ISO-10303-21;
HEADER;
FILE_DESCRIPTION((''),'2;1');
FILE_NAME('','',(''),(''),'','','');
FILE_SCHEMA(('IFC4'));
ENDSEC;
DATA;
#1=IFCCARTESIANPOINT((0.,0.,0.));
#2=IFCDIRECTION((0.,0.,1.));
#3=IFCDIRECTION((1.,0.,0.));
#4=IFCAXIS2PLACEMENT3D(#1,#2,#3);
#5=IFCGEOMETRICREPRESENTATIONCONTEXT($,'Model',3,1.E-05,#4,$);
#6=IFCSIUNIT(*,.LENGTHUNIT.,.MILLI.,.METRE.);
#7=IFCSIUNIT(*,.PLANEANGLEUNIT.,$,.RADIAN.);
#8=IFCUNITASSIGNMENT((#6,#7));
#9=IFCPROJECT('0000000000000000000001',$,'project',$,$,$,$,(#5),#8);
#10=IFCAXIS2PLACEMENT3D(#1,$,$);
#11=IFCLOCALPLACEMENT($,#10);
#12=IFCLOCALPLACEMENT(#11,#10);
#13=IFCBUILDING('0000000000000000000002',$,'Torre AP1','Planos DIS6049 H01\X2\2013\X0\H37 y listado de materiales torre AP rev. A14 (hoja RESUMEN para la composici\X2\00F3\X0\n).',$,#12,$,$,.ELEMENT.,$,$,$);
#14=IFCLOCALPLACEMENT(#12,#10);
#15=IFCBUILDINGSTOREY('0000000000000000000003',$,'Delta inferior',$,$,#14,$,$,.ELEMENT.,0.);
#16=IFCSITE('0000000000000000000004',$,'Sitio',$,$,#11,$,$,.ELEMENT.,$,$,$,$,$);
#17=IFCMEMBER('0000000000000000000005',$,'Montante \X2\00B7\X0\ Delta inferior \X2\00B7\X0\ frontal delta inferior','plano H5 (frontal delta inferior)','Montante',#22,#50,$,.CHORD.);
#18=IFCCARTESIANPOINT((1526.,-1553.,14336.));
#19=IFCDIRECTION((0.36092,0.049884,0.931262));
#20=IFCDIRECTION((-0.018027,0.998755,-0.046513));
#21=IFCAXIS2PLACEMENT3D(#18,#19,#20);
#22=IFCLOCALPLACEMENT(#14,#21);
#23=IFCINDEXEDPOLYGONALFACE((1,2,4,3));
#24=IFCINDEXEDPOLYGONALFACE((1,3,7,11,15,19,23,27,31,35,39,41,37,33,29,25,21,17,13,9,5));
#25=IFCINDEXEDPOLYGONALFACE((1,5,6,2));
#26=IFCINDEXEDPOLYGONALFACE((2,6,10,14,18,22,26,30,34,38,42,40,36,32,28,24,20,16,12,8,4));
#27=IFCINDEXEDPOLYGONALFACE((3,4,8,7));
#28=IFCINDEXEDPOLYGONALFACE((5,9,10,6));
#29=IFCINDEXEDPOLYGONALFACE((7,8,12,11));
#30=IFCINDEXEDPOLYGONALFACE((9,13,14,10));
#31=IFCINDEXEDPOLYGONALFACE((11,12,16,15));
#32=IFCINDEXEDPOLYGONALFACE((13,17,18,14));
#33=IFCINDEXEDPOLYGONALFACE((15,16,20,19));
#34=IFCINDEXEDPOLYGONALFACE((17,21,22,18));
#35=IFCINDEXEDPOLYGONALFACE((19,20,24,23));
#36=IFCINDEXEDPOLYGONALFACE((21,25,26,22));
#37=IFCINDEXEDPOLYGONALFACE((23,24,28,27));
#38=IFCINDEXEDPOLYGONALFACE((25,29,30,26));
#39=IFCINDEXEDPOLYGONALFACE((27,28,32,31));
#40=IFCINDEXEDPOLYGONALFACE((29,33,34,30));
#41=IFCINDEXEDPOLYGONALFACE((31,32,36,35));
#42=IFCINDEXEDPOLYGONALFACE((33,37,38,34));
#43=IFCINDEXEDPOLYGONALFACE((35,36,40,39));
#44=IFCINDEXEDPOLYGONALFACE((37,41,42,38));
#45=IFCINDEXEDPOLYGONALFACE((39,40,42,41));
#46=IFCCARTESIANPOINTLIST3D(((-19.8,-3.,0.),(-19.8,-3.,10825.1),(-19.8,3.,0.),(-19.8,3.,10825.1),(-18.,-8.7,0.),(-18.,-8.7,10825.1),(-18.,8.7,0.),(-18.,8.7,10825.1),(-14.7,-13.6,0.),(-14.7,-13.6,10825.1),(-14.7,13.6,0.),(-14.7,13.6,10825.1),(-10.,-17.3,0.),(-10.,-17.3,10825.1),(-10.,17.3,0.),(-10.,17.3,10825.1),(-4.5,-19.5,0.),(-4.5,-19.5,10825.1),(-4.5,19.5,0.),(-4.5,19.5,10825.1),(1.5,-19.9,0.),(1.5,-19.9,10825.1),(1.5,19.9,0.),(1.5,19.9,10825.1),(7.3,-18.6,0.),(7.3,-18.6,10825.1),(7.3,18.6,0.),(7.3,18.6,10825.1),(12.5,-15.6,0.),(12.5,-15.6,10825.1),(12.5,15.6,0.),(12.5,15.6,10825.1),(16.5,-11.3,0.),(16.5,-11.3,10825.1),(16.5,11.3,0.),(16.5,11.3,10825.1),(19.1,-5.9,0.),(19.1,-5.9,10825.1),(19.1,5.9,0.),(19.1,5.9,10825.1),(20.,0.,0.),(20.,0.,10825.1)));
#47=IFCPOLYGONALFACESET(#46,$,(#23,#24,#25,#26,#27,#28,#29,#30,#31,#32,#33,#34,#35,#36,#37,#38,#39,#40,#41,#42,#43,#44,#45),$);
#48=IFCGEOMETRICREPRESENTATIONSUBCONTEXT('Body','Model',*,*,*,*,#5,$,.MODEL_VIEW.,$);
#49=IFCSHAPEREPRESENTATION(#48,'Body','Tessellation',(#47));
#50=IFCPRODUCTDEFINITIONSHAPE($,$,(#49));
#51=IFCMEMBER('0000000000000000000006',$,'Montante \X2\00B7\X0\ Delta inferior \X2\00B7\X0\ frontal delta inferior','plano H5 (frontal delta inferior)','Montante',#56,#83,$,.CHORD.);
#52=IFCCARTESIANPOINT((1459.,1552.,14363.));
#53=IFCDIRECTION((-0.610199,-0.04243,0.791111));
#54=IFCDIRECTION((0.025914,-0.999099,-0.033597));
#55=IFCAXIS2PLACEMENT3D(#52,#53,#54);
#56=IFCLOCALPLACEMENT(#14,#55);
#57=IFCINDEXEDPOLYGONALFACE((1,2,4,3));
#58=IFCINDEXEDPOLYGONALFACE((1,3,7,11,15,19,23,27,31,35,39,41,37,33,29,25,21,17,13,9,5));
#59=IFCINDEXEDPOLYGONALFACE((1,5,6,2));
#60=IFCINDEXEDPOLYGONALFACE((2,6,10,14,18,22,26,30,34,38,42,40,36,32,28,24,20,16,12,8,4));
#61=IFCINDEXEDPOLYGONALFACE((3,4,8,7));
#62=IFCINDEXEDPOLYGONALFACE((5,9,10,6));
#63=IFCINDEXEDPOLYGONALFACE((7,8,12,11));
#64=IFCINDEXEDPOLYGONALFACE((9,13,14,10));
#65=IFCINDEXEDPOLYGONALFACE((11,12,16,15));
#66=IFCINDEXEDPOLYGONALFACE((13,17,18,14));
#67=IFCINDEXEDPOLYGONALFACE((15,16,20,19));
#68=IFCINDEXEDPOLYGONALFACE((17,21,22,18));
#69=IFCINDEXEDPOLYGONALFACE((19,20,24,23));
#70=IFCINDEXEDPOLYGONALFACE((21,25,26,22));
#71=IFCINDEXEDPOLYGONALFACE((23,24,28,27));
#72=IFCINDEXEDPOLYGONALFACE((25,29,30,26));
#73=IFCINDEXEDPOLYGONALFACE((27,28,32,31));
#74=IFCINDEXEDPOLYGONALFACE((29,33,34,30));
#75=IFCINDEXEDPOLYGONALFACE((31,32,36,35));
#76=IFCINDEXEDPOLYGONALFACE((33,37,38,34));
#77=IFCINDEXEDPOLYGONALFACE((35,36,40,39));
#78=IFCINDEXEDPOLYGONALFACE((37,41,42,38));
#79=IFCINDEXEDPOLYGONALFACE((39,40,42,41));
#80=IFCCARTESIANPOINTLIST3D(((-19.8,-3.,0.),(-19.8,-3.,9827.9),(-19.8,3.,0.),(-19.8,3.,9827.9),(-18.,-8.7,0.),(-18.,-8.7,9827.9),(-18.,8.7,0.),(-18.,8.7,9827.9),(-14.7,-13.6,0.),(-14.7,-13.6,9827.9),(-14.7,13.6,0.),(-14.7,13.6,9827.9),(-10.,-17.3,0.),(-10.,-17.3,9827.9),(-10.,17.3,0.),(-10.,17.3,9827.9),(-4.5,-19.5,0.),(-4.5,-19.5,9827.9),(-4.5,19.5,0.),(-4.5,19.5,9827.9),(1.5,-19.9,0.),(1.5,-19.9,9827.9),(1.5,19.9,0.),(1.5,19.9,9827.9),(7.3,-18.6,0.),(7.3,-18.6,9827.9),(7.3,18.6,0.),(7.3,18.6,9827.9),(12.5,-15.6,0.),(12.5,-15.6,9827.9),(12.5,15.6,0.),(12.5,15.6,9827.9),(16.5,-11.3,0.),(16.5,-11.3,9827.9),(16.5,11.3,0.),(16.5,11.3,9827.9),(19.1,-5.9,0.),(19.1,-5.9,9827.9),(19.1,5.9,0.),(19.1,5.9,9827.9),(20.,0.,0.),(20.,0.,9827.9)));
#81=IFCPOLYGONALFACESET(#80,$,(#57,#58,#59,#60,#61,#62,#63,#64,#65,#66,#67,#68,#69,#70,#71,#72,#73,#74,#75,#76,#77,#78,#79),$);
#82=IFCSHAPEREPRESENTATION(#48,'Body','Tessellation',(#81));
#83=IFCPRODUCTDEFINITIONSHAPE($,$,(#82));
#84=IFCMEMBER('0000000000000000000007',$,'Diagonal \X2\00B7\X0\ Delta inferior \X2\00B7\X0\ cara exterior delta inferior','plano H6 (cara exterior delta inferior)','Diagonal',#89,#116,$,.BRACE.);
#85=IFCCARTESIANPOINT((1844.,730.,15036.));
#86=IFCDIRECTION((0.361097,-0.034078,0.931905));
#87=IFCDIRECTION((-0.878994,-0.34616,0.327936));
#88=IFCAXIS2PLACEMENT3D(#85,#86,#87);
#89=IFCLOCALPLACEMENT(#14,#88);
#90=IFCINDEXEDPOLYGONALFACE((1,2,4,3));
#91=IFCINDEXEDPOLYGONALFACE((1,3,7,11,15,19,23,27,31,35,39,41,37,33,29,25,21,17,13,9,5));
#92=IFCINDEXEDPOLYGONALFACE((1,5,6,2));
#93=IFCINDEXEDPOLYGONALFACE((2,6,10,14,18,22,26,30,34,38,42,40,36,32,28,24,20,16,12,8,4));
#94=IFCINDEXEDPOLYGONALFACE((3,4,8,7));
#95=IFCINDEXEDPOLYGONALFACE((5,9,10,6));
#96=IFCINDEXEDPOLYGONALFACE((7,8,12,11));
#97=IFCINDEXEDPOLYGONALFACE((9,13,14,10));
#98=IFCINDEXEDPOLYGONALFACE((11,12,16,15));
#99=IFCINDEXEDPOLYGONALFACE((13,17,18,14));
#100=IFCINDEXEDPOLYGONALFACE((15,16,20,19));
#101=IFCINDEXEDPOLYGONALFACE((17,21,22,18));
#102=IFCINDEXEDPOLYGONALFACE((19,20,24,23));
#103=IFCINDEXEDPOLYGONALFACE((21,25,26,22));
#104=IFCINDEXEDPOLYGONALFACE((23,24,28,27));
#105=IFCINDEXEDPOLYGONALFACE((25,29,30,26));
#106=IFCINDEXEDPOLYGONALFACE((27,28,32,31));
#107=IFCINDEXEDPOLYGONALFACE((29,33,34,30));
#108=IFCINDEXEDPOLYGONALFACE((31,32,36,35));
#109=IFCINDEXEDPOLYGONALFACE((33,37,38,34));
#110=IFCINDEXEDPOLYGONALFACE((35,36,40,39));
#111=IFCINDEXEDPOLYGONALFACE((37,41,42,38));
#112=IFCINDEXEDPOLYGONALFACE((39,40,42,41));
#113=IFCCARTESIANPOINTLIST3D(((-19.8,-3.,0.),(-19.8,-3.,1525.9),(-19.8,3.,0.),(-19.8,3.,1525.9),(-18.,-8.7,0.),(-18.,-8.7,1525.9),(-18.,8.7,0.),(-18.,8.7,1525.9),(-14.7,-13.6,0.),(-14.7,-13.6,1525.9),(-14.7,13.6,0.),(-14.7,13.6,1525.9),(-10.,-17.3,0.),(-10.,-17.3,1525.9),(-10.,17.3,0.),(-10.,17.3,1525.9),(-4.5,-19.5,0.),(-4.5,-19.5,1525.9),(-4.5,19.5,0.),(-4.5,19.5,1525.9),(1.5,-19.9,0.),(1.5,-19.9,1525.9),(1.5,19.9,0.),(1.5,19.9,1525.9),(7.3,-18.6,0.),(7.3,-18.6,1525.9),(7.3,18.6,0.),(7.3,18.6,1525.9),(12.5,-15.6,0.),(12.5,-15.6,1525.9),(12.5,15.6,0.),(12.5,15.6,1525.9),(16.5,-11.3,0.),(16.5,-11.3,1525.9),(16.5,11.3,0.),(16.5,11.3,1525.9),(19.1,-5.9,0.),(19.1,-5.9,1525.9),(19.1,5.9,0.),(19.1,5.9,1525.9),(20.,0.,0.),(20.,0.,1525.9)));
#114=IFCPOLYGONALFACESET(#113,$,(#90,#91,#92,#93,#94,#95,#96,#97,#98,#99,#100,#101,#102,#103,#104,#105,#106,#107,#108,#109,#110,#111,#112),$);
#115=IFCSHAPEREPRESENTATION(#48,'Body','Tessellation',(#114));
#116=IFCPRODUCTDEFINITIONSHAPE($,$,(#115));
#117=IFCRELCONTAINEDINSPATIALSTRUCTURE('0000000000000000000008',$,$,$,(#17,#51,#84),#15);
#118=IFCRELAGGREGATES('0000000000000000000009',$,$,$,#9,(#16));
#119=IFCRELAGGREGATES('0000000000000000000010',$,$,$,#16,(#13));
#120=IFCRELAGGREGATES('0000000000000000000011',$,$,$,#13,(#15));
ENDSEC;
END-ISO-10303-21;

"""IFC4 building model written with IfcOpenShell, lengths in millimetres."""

from ifc_helpers import new_model, si_unit, frame, origin, origin_with_axes, place, context, subcontext, project, spatial, circle, extrude, element, save


model = new_model("IFC4")

# Units and contexts
model_context = context("Model", 3, precision=1e-05, world=origin_with_axes())
body_context = subcontext(model_context, "Body", "Model", "MODEL_VIEW")
ifc_project = project(units=[si_unit("LENGTHUNIT", "METRE", prefix="MILLI"), si_unit("PLANEANGLEUNIT", "RADIAN")], contexts=[model_context])

# Site, building, storey
site_placement = place(None, origin())
site = spatial("IfcSite", under=ifc_project, at=site_placement, Name="Sitio", CompositionType="ELEMENT")
building_placement = place(site_placement, origin())
building = spatial("IfcBuilding", under=site, at=building_placement, Name="Torre AP1", Description="Planos DIS6049 H01–H37 y listado de materiales torre AP rev. A14 (hoja RESUMEN para la composición).", CompositionType="ELEMENT")
storey_placement = place(building_placement, origin())
storey = spatial("IfcBuildingStorey", under=building, at=storey_placement, Name="Delta inferior", CompositionType="ELEMENT", Elevation=0.0)

# Members
for number, where, z_axis, x_axis, name in (
    (1, (1526.0, -1553.0, 14336.0), (0.36092, 0.049884, 0.931262), (-0.018027, 0.998755, -0.046513), "Montante · Delta inferior · frontal delta inferior"),
):
    element("IfcMember", number, at=place(storey_placement, frame(where, z_axis=z_axis, x_axis=x_axis)), inside=storey, Name=name, Description="plano H5 (frontal delta inferior)", ObjectType="Montante", PredefinedType="CHORD", context=body_context, shape_type="SweptSolid", body=[
        extrude(circle(Radius=20.0), None, (0.0, 0.0, 1.0), 10825.1),
    ])
for number, where, z_axis, x_axis, name in (
    (2, (1459.0, 1552.0, 14363.0), (-0.610199, -0.04243, 0.791111), (0.025914, -0.999099, -0.033597), "Montante · Delta inferior · frontal delta inferior"),
):
    element("IfcMember", number, at=place(storey_placement, frame(where, z_axis=z_axis, x_axis=x_axis)), inside=storey, Name=name, Description="plano H5 (frontal delta inferior)", ObjectType="Montante", PredefinedType="CHORD", context=body_context, shape_type="SweptSolid", body=[
        extrude(circle(Radius=20.0), None, (0.0, 0.0, 1.0), 9827.9),
    ])
member_1_placement = place(storey_placement, frame((1844.0, 730.0, 15036.0), z_axis=(0.361097, -0.034078, 0.931905), x_axis=(-0.878994, -0.34616, 0.327936)))
element("IfcMember", 3, at=member_1_placement, inside=storey, Name="Diagonal · Delta inferior · cara exterior delta inferior", Description="plano H6 (cara exterior delta inferior)", ObjectType="Diagonal", PredefinedType="BRACE", context=body_context, shape_type="SweptSolid", body=[
    extrude(circle(Radius=20.0), None, (0.0, 0.0, 1.0), 1525.9),
])

save(model, "model.ifc")
